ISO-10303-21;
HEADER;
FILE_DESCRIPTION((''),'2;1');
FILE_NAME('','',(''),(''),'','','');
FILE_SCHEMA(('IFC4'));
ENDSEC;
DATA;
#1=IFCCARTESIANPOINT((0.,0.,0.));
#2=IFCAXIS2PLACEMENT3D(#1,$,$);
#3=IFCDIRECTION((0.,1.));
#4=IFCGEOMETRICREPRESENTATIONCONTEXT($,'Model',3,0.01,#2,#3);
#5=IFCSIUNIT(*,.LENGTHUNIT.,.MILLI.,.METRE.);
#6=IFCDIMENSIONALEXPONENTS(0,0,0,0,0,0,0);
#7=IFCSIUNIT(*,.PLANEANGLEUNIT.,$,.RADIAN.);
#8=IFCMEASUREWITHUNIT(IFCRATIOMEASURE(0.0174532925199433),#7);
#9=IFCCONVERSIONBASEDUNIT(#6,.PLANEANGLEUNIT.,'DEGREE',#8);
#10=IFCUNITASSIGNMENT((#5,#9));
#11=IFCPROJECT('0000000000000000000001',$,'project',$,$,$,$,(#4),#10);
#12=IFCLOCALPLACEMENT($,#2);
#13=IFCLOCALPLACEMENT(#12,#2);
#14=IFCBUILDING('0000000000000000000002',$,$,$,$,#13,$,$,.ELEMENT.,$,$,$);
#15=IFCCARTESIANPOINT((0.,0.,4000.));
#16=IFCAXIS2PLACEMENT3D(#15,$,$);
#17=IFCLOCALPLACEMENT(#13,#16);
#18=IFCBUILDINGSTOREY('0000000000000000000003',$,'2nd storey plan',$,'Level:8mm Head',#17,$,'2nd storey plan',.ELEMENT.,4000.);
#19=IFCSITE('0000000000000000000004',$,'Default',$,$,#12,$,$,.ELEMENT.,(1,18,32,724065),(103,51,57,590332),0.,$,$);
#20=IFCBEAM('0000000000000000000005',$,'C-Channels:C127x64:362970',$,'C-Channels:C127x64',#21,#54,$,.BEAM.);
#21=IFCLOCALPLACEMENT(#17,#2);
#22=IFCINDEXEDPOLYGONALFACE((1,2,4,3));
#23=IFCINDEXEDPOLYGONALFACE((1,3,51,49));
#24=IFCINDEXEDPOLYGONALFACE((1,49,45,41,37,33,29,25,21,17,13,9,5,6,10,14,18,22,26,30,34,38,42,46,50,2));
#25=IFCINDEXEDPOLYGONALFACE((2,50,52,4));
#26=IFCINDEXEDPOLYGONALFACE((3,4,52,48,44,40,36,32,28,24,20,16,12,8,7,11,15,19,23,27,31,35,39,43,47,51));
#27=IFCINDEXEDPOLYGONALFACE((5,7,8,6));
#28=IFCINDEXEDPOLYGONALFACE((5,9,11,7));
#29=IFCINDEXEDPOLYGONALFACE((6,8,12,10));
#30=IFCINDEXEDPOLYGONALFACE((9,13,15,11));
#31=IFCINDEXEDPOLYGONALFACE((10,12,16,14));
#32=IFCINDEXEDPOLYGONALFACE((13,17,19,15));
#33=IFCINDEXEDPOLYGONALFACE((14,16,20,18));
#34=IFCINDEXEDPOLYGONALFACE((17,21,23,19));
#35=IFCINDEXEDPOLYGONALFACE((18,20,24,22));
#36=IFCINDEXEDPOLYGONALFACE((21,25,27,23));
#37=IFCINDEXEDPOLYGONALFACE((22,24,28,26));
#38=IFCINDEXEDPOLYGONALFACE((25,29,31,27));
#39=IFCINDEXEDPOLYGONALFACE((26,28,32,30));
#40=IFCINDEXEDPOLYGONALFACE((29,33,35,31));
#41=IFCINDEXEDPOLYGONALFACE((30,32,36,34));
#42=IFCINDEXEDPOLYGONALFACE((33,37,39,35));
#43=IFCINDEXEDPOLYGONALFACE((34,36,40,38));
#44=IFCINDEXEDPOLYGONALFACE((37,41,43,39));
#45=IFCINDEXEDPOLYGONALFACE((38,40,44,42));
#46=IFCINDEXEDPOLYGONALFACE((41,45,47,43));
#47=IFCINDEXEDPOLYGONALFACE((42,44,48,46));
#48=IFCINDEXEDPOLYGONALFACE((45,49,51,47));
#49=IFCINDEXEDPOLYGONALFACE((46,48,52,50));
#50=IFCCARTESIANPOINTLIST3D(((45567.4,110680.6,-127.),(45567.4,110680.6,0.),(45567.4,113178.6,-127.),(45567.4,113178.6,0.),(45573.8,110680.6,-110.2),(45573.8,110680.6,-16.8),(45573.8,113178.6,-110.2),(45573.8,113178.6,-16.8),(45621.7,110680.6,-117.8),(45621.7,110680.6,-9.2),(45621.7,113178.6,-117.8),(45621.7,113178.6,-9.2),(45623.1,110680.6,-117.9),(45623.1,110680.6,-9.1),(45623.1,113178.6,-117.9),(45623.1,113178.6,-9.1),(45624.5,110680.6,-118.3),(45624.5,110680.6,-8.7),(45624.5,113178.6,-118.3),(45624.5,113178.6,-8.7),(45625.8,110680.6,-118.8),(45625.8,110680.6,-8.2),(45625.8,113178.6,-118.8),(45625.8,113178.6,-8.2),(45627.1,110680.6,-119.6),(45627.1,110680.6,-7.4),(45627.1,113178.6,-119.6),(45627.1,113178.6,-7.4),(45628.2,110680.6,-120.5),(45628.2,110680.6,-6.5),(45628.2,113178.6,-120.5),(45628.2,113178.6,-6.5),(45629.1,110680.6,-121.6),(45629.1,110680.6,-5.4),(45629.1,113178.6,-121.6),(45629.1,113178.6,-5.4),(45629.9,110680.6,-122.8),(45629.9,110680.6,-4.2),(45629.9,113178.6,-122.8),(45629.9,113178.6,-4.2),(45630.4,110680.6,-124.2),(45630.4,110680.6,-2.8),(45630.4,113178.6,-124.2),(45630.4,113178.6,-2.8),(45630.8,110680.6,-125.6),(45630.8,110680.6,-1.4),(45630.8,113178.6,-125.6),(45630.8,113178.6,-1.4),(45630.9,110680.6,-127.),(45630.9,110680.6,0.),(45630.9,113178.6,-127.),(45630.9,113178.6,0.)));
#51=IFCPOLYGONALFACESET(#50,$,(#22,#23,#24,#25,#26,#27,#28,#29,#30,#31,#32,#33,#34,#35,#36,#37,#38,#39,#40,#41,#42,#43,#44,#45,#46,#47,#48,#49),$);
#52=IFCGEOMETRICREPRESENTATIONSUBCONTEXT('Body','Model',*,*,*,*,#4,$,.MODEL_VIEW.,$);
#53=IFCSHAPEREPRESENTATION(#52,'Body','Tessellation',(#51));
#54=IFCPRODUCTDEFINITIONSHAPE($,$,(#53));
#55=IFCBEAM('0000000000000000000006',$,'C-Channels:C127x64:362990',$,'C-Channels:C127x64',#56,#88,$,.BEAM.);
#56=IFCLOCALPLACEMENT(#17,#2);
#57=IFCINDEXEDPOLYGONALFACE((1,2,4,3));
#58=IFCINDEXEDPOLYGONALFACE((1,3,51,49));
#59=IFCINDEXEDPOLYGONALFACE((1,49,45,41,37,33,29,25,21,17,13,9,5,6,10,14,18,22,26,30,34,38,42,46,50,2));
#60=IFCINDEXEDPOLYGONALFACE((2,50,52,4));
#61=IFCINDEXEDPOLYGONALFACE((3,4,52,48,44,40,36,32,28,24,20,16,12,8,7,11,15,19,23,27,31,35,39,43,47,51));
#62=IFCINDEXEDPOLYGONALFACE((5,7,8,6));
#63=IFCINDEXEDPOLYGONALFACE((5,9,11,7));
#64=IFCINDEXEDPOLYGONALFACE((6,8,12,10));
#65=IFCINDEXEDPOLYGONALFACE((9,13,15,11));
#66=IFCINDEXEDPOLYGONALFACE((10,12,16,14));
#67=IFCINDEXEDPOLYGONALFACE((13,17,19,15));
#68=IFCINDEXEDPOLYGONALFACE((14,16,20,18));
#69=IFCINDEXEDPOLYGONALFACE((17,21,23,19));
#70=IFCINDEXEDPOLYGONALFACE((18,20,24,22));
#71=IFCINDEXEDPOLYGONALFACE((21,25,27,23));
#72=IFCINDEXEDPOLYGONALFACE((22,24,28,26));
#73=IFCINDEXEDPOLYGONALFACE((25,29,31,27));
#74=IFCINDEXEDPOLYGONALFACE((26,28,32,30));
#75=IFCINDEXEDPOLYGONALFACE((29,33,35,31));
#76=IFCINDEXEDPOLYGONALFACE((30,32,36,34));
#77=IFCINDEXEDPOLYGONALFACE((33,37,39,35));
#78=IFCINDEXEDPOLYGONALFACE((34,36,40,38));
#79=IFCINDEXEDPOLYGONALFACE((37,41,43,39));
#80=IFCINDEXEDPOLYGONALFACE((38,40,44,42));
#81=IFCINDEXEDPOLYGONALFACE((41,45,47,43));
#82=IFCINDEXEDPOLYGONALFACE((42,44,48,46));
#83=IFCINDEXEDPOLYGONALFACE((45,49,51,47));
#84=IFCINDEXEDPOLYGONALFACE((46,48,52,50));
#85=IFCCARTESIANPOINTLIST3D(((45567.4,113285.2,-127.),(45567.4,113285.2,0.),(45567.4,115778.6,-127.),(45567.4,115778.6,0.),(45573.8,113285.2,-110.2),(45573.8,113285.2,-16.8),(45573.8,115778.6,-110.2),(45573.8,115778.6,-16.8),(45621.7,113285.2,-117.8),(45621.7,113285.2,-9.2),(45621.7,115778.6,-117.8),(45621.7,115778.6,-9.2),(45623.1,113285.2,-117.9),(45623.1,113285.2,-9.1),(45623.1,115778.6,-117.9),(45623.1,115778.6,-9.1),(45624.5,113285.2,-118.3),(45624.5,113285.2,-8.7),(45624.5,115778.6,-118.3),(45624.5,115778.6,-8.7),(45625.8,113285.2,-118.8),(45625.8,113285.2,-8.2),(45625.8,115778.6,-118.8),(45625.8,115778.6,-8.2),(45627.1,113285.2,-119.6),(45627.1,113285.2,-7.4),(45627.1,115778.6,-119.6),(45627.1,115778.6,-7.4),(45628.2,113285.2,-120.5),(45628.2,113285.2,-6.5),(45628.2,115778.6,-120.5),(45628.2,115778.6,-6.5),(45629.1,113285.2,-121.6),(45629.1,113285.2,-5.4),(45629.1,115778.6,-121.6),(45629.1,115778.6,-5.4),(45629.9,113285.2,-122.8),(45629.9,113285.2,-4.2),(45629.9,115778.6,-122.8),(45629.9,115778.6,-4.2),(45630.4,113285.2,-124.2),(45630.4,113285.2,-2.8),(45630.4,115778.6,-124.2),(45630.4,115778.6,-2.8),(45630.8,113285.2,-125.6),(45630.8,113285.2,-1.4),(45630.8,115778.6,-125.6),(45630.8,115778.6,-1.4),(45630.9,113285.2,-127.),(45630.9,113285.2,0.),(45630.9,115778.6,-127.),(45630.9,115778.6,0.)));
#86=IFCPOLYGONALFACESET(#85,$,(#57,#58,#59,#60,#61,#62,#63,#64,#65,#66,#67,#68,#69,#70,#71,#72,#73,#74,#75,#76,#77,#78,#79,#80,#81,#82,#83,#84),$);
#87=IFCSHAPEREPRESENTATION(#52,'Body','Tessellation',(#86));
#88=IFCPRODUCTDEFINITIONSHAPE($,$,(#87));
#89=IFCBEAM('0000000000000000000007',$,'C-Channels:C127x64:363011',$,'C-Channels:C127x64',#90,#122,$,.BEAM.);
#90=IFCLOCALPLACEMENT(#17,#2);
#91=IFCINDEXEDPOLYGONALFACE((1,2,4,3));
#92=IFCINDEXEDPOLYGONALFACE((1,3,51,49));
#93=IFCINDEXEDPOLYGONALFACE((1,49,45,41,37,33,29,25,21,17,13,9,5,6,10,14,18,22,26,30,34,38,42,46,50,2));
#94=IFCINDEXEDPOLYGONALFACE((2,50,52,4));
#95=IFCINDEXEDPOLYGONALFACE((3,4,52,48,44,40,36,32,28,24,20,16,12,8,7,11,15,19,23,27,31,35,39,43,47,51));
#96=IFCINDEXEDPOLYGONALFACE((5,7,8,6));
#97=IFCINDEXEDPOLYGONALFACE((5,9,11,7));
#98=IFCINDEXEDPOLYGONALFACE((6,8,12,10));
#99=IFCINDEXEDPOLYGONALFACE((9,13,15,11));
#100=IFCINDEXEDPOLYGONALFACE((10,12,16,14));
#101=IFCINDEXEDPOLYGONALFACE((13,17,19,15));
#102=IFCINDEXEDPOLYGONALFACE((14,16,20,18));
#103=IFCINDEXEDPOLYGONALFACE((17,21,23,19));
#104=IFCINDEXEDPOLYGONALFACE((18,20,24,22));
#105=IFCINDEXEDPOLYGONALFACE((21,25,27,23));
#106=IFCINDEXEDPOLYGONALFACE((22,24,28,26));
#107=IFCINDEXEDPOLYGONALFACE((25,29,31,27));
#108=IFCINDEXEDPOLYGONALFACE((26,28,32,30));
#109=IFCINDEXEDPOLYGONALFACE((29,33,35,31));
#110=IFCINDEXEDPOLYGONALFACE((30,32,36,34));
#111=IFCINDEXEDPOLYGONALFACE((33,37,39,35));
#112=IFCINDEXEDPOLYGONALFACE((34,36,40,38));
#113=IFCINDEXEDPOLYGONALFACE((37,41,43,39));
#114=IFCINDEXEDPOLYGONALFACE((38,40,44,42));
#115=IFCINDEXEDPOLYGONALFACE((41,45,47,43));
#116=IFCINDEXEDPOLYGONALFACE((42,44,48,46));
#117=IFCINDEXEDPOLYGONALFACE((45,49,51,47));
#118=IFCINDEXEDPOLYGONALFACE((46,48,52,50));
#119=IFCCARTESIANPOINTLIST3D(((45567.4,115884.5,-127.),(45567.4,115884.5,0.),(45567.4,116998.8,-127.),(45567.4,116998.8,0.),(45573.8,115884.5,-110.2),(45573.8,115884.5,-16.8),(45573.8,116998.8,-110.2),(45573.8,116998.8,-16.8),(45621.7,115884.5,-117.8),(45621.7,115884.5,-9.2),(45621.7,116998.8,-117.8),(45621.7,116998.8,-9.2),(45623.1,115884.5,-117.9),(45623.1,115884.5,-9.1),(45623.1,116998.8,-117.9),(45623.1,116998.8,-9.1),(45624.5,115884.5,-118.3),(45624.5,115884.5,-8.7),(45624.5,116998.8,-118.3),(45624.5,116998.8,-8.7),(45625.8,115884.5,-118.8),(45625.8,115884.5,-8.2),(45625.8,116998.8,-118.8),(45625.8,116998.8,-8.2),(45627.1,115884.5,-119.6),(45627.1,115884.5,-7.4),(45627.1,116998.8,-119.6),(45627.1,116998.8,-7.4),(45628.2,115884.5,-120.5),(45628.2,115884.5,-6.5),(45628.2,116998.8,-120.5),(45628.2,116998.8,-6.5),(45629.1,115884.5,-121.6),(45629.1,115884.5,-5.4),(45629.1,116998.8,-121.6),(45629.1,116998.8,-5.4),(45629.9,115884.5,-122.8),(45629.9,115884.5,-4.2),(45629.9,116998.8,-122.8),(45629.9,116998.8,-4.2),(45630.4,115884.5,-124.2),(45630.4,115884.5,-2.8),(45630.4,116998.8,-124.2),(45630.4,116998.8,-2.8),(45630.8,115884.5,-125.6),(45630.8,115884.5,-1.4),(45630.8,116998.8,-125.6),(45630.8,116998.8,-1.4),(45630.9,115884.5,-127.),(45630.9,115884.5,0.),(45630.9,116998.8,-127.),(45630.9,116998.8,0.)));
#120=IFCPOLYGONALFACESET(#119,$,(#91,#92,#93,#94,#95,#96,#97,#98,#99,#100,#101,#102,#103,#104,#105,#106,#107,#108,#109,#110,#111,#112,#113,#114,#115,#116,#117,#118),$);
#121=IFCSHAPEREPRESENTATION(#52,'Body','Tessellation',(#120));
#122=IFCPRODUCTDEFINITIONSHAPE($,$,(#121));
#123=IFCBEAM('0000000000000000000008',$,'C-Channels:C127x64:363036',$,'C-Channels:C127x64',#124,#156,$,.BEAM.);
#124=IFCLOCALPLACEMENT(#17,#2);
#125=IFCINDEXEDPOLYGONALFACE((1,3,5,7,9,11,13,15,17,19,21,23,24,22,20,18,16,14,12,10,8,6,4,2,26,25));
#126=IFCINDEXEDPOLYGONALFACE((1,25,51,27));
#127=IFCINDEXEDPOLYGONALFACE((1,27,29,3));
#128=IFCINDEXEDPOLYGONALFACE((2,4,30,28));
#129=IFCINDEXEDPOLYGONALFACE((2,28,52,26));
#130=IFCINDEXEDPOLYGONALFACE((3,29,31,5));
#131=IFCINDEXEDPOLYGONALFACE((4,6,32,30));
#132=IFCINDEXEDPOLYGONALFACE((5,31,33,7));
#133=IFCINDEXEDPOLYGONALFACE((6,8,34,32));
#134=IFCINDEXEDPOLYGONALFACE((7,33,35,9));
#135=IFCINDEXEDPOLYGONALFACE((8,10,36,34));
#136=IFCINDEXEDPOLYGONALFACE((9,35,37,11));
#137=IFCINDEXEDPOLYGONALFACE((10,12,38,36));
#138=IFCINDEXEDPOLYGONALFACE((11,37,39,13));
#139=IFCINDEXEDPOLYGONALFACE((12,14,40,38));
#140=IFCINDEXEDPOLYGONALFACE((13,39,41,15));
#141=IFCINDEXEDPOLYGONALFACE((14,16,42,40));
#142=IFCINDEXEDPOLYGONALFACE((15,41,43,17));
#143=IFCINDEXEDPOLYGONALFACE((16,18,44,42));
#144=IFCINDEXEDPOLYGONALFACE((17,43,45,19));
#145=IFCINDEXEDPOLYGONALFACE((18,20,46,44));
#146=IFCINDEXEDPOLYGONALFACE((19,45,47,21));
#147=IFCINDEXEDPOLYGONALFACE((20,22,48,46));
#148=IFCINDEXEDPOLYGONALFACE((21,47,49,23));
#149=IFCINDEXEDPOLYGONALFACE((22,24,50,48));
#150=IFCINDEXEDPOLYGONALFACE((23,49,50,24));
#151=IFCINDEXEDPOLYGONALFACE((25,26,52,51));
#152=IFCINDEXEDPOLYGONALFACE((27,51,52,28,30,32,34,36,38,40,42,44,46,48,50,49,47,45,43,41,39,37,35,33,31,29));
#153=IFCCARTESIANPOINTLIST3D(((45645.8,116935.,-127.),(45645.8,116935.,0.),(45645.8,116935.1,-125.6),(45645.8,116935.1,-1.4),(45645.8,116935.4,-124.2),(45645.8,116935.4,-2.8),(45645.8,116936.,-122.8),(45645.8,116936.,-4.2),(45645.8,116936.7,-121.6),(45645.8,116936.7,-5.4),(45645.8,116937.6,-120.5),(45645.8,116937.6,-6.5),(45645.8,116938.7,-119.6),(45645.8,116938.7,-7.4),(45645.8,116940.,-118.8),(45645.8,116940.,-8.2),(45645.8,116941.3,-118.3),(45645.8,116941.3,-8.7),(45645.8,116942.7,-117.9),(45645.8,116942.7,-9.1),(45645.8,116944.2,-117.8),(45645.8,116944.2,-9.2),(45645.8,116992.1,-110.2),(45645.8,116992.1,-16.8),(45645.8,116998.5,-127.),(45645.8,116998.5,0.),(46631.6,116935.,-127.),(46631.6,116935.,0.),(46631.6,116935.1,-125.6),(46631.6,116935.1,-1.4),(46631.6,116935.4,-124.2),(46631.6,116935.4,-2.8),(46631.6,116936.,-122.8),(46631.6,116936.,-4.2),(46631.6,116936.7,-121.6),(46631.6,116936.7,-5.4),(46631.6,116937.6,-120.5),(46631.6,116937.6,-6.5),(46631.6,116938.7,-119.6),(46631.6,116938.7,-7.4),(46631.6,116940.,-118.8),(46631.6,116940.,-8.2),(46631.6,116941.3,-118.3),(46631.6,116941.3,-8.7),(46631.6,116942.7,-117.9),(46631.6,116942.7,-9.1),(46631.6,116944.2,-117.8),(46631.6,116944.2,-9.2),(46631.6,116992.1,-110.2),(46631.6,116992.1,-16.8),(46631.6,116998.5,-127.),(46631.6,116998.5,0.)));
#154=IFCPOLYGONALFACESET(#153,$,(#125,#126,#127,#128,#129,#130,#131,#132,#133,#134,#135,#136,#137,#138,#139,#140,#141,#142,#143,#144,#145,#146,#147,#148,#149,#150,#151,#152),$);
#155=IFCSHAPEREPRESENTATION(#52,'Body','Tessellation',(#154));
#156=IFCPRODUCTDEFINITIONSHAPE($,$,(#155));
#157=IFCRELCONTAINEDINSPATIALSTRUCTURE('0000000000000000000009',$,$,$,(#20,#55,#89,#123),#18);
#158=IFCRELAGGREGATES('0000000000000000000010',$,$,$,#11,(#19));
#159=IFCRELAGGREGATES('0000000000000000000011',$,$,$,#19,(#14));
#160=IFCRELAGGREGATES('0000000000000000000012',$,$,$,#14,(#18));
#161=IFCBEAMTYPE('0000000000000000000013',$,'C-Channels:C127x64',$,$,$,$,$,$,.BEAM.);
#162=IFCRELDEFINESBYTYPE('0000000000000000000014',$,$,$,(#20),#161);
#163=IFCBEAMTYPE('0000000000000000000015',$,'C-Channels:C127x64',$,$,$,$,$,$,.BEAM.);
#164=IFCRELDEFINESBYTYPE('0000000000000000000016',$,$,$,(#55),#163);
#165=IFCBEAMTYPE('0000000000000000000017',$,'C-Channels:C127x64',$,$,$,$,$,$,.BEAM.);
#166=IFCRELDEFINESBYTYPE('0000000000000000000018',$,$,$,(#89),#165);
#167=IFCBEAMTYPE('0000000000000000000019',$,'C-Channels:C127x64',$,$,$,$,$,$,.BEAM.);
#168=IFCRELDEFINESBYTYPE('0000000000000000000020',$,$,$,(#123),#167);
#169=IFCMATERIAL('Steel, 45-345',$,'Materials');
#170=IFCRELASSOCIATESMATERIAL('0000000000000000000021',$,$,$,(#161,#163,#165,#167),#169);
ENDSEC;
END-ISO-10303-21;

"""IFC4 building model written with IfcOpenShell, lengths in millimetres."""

from ifc_helpers import new_model, entity, si_unit, converted_unit, direction, frame, origin, place, context, subcontext, project, spatial, indexed_curve, outline, extrude, source, transform, mapped, material, type_object, type_shapes, element, save


model = new_model("IFC4")

# Units and contexts
model_context = context("Model", 3, precision=0.01, world=origin(), true_north=direction((0.0, 1.0)))
body_context = subcontext(model_context, "Body", "Model", "MODEL_VIEW")
ifc_project = project(units=[si_unit("LENGTHUNIT", "METRE", prefix="MILLI"), converted_unit("PLANEANGLEUNIT", "DEGREE", entity("IfcRatioMeasure", 0.0174532925199433), si_unit("PLANEANGLEUNIT", "RADIAN"), dimensions=[0, 0, 0, 0, 0, 0, 0])], contexts=[model_context])

# Site, building, storey
site_placement = place(None, origin())
site = spatial("IfcSite", under=ifc_project, at=site_placement, Name="Default", CompositionType="ELEMENT", RefLatitude=(1, 18, 32, 724065), RefLongitude=(103, 51, 57, 590332), RefElevation=0.0)
building_placement = place(site_placement, origin())
building = spatial("IfcBuilding", under=site, at=building_placement, CompositionType="ELEMENT")
storey_placement = place(building_placement, frame((0.0, 0.0, 4000.0)))
storey = spatial("IfcBuildingStorey", under=building, at=storey_placement, Name="2nd storey plan", ObjectType="Level:8mm Head", LongName="2nd storey plan", CompositionType="ELEMENT", Elevation=4000.0)

# Beams
ifc_material_1 = material(Name="Steel, 45-345", Category="Materials")
beam_type_1 = type_object("IfcBeamType", Name="C-Channels:C127x64", PredefinedType="BEAM", material=ifc_material_1)
shared_shape_1 = source(origin(), body_context, "Body", "SweptSolid", [
    extrude(outline(indexed_curve([(-32.5, -63.5), (31.0, -63.5), (31.0, 63.5), (-32.4, 63.5), (-32.3, 62.1), (-32.0, 60.7), (-31.4, 59.3), (-30.7, 58.1), (-29.8, 57.0), (-28.7, 56.1), (-27.4, 55.3), (-26.1, 54.8), (-24.7, 54.4), (-23.2, 54.3), (24.6, 46.7), (24.6, -46.7), (-23.2, -54.3), (-24.7, -54.4), (-26.1, -54.8), (-27.4, -55.3), (-28.7, -56.1), (-29.8, -57.0), (-30.7, -58.1), (-31.4, -59.3), (-32.0, -60.7), (-32.3, -62.1), (-32.5, -63.5)], self_intersect=False)), frame((-1249.0, -11.7, 0.0), z_axis=(1.0, 0.0, 0.0), x_axis=(0.0, 1.0, 0.0)), (0.0, 0.0, 1.0), 2498.0),
])
type_shapes(beam_type_1, [shared_shape_1])
beam_1_placement = place(storey_placement, frame((45586.8, 111929.6, -63.5), z_axis=(0.0, 0.0, 1.0), x_axis=(0.0, 1.0, 0.0)))
element("IfcBeam", 1, at=beam_1_placement, inside=storey, type_object=beam_type_1, Name="C-Channels:C127x64:362970", ObjectType="C-Channels:C127x64", PredefinedType="BEAM", context=body_context, shape_type="MappedRepresentation", body=[
    mapped(shared_shape_1, transform((0.0, 0.0, 0.0), scale=1.0)),
])
beam_type_2 = type_object("IfcBeamType", Name="C-Channels:C127x64", PredefinedType="BEAM", material=ifc_material_1)
shared_shape_2 = source(origin(), body_context, "Body", "SweptSolid", [
    extrude(outline(indexed_curve([(-32.5, -63.5), (31.0, -63.5), (31.0, 63.5), (-32.4, 63.5), (-32.3, 62.1), (-32.0, 60.7), (-31.4, 59.3), (-30.7, 58.1), (-29.8, 57.0), (-28.7, 56.1), (-27.4, 55.3), (-26.1, 54.8), (-24.7, 54.4), (-23.2, 54.3), (24.6, 46.7), (24.6, -46.7), (-23.2, -54.3), (-24.7, -54.4), (-26.1, -54.8), (-27.4, -55.3), (-28.7, -56.1), (-29.8, -57.0), (-30.7, -58.1), (-31.4, -59.3), (-32.0, -60.7), (-32.3, -62.1), (-32.5, -63.5)], self_intersect=False)), frame((-1244.4, -11.7, 0.0), z_axis=(1.0, 0.0, 0.0), x_axis=(0.0, 1.0, 0.0)), (0.0, 0.0, 1.0), 2493.4),
])
type_shapes(beam_type_2, [shared_shape_2])
beam_2_placement = place(storey_placement, frame((45586.8, 114529.6, -63.5), z_axis=(0.0, 0.0, 1.0), x_axis=(0.0, 1.0, 0.0)))
element("IfcBeam", 2, at=beam_2_placement, inside=storey, type_object=beam_type_2, Name="C-Channels:C127x64:362990", ObjectType="C-Channels:C127x64", PredefinedType="BEAM", context=body_context, shape_type="MappedRepresentation", body=[
    mapped(shared_shape_2, transform((0.0, 0.0, 0.0), scale=1.0)),
])
beam_type_3 = type_object("IfcBeamType", Name="C-Channels:C127x64", PredefinedType="BEAM", material=ifc_material_1)
shared_shape_3 = source(origin(), body_context, "Body", "SweptSolid", [
    extrude(outline(indexed_curve([(-32.5, -63.5), (31.0, -63.5), (31.0, 63.5), (-32.4, 63.5), (-32.3, 62.1), (-32.0, 60.7), (-31.4, 59.3), (-30.7, 58.1), (-29.8, 57.0), (-28.7, 56.1), (-27.4, 55.3), (-26.1, 54.8), (-24.7, 54.4), (-23.2, 54.3), (24.6, 46.7), (24.6, -46.7), (-23.2, -54.3), (-24.7, -54.4), (-26.1, -54.8), (-27.4, -55.3), (-28.7, -56.1), (-29.8, -57.0), (-30.7, -58.1), (-31.4, -59.3), (-32.0, -60.7), (-32.3, -62.1), (-32.5, -63.5)], self_intersect=False)), frame((-519.9, -11.7, 0.0), z_axis=(1.0, 0.0, 0.0), x_axis=(0.0, 1.0, 0.0)), (0.0, 0.0, 1.0), 1114.4),
])
type_shapes(beam_type_3, [shared_shape_3])
beam_3_placement = place(storey_placement, frame((45586.8, 116404.3, -63.5), z_axis=(0.0, 0.0, 1.0), x_axis=(0.0, 1.0, 0.0)))
element("IfcBeam", 3, at=beam_3_placement, inside=storey, type_object=beam_type_3, Name="C-Channels:C127x64:363011", ObjectType="C-Channels:C127x64", PredefinedType="BEAM", context=body_context, shape_type="MappedRepresentation", body=[
    mapped(shared_shape_3, transform((0.0, 0.0, 0.0), scale=1.0)),
])
beam_type_4 = type_object("IfcBeamType", Name="C-Channels:C127x64", PredefinedType="BEAM", material=ifc_material_1)
shared_shape_4 = source(origin(), body_context, "Body", "SweptSolid", [
    extrude(outline(indexed_curve([(-32.5, -63.5), (31.0, -63.5), (31.0, 63.5), (-32.4, 63.5), (-32.3, 62.1), (-32.0, 60.7), (-31.4, 59.3), (-30.7, 58.1), (-29.8, 57.0), (-28.7, 56.1), (-27.4, 55.3), (-26.1, 54.8), (-24.7, 54.4), (-23.2, 54.3), (24.6, 46.7), (24.6, -46.7), (-23.2, -54.3), (-24.7, -54.4), (-26.1, -54.8), (-27.4, -55.3), (-28.7, -56.1), (-29.8, -57.0), (-30.7, -58.1), (-31.4, -59.3), (-32.0, -60.7), (-32.3, -62.1), (-32.5, -63.5)], self_intersect=False)), frame((-491.0, -11.7, 0.0), z_axis=(1.0, 0.0, 0.0), x_axis=(0.0, 1.0, 0.0)), (0.0, 0.0, 1.0), 985.8),
])
type_shapes(beam_type_4, [shared_shape_4])
beam_4_placement = place(storey_placement, frame((46136.8, 116979.1, -63.5)))
element("IfcBeam", 4, at=beam_4_placement, inside=storey, type_object=beam_type_4, Name="C-Channels:C127x64:363036", ObjectType="C-Channels:C127x64", PredefinedType="BEAM", context=body_context, shape_type="MappedRepresentation", body=[
    mapped(shared_shape_4, transform((0.0, 0.0, 0.0), scale=1.0)),
])

save(model, "model.ifc")
